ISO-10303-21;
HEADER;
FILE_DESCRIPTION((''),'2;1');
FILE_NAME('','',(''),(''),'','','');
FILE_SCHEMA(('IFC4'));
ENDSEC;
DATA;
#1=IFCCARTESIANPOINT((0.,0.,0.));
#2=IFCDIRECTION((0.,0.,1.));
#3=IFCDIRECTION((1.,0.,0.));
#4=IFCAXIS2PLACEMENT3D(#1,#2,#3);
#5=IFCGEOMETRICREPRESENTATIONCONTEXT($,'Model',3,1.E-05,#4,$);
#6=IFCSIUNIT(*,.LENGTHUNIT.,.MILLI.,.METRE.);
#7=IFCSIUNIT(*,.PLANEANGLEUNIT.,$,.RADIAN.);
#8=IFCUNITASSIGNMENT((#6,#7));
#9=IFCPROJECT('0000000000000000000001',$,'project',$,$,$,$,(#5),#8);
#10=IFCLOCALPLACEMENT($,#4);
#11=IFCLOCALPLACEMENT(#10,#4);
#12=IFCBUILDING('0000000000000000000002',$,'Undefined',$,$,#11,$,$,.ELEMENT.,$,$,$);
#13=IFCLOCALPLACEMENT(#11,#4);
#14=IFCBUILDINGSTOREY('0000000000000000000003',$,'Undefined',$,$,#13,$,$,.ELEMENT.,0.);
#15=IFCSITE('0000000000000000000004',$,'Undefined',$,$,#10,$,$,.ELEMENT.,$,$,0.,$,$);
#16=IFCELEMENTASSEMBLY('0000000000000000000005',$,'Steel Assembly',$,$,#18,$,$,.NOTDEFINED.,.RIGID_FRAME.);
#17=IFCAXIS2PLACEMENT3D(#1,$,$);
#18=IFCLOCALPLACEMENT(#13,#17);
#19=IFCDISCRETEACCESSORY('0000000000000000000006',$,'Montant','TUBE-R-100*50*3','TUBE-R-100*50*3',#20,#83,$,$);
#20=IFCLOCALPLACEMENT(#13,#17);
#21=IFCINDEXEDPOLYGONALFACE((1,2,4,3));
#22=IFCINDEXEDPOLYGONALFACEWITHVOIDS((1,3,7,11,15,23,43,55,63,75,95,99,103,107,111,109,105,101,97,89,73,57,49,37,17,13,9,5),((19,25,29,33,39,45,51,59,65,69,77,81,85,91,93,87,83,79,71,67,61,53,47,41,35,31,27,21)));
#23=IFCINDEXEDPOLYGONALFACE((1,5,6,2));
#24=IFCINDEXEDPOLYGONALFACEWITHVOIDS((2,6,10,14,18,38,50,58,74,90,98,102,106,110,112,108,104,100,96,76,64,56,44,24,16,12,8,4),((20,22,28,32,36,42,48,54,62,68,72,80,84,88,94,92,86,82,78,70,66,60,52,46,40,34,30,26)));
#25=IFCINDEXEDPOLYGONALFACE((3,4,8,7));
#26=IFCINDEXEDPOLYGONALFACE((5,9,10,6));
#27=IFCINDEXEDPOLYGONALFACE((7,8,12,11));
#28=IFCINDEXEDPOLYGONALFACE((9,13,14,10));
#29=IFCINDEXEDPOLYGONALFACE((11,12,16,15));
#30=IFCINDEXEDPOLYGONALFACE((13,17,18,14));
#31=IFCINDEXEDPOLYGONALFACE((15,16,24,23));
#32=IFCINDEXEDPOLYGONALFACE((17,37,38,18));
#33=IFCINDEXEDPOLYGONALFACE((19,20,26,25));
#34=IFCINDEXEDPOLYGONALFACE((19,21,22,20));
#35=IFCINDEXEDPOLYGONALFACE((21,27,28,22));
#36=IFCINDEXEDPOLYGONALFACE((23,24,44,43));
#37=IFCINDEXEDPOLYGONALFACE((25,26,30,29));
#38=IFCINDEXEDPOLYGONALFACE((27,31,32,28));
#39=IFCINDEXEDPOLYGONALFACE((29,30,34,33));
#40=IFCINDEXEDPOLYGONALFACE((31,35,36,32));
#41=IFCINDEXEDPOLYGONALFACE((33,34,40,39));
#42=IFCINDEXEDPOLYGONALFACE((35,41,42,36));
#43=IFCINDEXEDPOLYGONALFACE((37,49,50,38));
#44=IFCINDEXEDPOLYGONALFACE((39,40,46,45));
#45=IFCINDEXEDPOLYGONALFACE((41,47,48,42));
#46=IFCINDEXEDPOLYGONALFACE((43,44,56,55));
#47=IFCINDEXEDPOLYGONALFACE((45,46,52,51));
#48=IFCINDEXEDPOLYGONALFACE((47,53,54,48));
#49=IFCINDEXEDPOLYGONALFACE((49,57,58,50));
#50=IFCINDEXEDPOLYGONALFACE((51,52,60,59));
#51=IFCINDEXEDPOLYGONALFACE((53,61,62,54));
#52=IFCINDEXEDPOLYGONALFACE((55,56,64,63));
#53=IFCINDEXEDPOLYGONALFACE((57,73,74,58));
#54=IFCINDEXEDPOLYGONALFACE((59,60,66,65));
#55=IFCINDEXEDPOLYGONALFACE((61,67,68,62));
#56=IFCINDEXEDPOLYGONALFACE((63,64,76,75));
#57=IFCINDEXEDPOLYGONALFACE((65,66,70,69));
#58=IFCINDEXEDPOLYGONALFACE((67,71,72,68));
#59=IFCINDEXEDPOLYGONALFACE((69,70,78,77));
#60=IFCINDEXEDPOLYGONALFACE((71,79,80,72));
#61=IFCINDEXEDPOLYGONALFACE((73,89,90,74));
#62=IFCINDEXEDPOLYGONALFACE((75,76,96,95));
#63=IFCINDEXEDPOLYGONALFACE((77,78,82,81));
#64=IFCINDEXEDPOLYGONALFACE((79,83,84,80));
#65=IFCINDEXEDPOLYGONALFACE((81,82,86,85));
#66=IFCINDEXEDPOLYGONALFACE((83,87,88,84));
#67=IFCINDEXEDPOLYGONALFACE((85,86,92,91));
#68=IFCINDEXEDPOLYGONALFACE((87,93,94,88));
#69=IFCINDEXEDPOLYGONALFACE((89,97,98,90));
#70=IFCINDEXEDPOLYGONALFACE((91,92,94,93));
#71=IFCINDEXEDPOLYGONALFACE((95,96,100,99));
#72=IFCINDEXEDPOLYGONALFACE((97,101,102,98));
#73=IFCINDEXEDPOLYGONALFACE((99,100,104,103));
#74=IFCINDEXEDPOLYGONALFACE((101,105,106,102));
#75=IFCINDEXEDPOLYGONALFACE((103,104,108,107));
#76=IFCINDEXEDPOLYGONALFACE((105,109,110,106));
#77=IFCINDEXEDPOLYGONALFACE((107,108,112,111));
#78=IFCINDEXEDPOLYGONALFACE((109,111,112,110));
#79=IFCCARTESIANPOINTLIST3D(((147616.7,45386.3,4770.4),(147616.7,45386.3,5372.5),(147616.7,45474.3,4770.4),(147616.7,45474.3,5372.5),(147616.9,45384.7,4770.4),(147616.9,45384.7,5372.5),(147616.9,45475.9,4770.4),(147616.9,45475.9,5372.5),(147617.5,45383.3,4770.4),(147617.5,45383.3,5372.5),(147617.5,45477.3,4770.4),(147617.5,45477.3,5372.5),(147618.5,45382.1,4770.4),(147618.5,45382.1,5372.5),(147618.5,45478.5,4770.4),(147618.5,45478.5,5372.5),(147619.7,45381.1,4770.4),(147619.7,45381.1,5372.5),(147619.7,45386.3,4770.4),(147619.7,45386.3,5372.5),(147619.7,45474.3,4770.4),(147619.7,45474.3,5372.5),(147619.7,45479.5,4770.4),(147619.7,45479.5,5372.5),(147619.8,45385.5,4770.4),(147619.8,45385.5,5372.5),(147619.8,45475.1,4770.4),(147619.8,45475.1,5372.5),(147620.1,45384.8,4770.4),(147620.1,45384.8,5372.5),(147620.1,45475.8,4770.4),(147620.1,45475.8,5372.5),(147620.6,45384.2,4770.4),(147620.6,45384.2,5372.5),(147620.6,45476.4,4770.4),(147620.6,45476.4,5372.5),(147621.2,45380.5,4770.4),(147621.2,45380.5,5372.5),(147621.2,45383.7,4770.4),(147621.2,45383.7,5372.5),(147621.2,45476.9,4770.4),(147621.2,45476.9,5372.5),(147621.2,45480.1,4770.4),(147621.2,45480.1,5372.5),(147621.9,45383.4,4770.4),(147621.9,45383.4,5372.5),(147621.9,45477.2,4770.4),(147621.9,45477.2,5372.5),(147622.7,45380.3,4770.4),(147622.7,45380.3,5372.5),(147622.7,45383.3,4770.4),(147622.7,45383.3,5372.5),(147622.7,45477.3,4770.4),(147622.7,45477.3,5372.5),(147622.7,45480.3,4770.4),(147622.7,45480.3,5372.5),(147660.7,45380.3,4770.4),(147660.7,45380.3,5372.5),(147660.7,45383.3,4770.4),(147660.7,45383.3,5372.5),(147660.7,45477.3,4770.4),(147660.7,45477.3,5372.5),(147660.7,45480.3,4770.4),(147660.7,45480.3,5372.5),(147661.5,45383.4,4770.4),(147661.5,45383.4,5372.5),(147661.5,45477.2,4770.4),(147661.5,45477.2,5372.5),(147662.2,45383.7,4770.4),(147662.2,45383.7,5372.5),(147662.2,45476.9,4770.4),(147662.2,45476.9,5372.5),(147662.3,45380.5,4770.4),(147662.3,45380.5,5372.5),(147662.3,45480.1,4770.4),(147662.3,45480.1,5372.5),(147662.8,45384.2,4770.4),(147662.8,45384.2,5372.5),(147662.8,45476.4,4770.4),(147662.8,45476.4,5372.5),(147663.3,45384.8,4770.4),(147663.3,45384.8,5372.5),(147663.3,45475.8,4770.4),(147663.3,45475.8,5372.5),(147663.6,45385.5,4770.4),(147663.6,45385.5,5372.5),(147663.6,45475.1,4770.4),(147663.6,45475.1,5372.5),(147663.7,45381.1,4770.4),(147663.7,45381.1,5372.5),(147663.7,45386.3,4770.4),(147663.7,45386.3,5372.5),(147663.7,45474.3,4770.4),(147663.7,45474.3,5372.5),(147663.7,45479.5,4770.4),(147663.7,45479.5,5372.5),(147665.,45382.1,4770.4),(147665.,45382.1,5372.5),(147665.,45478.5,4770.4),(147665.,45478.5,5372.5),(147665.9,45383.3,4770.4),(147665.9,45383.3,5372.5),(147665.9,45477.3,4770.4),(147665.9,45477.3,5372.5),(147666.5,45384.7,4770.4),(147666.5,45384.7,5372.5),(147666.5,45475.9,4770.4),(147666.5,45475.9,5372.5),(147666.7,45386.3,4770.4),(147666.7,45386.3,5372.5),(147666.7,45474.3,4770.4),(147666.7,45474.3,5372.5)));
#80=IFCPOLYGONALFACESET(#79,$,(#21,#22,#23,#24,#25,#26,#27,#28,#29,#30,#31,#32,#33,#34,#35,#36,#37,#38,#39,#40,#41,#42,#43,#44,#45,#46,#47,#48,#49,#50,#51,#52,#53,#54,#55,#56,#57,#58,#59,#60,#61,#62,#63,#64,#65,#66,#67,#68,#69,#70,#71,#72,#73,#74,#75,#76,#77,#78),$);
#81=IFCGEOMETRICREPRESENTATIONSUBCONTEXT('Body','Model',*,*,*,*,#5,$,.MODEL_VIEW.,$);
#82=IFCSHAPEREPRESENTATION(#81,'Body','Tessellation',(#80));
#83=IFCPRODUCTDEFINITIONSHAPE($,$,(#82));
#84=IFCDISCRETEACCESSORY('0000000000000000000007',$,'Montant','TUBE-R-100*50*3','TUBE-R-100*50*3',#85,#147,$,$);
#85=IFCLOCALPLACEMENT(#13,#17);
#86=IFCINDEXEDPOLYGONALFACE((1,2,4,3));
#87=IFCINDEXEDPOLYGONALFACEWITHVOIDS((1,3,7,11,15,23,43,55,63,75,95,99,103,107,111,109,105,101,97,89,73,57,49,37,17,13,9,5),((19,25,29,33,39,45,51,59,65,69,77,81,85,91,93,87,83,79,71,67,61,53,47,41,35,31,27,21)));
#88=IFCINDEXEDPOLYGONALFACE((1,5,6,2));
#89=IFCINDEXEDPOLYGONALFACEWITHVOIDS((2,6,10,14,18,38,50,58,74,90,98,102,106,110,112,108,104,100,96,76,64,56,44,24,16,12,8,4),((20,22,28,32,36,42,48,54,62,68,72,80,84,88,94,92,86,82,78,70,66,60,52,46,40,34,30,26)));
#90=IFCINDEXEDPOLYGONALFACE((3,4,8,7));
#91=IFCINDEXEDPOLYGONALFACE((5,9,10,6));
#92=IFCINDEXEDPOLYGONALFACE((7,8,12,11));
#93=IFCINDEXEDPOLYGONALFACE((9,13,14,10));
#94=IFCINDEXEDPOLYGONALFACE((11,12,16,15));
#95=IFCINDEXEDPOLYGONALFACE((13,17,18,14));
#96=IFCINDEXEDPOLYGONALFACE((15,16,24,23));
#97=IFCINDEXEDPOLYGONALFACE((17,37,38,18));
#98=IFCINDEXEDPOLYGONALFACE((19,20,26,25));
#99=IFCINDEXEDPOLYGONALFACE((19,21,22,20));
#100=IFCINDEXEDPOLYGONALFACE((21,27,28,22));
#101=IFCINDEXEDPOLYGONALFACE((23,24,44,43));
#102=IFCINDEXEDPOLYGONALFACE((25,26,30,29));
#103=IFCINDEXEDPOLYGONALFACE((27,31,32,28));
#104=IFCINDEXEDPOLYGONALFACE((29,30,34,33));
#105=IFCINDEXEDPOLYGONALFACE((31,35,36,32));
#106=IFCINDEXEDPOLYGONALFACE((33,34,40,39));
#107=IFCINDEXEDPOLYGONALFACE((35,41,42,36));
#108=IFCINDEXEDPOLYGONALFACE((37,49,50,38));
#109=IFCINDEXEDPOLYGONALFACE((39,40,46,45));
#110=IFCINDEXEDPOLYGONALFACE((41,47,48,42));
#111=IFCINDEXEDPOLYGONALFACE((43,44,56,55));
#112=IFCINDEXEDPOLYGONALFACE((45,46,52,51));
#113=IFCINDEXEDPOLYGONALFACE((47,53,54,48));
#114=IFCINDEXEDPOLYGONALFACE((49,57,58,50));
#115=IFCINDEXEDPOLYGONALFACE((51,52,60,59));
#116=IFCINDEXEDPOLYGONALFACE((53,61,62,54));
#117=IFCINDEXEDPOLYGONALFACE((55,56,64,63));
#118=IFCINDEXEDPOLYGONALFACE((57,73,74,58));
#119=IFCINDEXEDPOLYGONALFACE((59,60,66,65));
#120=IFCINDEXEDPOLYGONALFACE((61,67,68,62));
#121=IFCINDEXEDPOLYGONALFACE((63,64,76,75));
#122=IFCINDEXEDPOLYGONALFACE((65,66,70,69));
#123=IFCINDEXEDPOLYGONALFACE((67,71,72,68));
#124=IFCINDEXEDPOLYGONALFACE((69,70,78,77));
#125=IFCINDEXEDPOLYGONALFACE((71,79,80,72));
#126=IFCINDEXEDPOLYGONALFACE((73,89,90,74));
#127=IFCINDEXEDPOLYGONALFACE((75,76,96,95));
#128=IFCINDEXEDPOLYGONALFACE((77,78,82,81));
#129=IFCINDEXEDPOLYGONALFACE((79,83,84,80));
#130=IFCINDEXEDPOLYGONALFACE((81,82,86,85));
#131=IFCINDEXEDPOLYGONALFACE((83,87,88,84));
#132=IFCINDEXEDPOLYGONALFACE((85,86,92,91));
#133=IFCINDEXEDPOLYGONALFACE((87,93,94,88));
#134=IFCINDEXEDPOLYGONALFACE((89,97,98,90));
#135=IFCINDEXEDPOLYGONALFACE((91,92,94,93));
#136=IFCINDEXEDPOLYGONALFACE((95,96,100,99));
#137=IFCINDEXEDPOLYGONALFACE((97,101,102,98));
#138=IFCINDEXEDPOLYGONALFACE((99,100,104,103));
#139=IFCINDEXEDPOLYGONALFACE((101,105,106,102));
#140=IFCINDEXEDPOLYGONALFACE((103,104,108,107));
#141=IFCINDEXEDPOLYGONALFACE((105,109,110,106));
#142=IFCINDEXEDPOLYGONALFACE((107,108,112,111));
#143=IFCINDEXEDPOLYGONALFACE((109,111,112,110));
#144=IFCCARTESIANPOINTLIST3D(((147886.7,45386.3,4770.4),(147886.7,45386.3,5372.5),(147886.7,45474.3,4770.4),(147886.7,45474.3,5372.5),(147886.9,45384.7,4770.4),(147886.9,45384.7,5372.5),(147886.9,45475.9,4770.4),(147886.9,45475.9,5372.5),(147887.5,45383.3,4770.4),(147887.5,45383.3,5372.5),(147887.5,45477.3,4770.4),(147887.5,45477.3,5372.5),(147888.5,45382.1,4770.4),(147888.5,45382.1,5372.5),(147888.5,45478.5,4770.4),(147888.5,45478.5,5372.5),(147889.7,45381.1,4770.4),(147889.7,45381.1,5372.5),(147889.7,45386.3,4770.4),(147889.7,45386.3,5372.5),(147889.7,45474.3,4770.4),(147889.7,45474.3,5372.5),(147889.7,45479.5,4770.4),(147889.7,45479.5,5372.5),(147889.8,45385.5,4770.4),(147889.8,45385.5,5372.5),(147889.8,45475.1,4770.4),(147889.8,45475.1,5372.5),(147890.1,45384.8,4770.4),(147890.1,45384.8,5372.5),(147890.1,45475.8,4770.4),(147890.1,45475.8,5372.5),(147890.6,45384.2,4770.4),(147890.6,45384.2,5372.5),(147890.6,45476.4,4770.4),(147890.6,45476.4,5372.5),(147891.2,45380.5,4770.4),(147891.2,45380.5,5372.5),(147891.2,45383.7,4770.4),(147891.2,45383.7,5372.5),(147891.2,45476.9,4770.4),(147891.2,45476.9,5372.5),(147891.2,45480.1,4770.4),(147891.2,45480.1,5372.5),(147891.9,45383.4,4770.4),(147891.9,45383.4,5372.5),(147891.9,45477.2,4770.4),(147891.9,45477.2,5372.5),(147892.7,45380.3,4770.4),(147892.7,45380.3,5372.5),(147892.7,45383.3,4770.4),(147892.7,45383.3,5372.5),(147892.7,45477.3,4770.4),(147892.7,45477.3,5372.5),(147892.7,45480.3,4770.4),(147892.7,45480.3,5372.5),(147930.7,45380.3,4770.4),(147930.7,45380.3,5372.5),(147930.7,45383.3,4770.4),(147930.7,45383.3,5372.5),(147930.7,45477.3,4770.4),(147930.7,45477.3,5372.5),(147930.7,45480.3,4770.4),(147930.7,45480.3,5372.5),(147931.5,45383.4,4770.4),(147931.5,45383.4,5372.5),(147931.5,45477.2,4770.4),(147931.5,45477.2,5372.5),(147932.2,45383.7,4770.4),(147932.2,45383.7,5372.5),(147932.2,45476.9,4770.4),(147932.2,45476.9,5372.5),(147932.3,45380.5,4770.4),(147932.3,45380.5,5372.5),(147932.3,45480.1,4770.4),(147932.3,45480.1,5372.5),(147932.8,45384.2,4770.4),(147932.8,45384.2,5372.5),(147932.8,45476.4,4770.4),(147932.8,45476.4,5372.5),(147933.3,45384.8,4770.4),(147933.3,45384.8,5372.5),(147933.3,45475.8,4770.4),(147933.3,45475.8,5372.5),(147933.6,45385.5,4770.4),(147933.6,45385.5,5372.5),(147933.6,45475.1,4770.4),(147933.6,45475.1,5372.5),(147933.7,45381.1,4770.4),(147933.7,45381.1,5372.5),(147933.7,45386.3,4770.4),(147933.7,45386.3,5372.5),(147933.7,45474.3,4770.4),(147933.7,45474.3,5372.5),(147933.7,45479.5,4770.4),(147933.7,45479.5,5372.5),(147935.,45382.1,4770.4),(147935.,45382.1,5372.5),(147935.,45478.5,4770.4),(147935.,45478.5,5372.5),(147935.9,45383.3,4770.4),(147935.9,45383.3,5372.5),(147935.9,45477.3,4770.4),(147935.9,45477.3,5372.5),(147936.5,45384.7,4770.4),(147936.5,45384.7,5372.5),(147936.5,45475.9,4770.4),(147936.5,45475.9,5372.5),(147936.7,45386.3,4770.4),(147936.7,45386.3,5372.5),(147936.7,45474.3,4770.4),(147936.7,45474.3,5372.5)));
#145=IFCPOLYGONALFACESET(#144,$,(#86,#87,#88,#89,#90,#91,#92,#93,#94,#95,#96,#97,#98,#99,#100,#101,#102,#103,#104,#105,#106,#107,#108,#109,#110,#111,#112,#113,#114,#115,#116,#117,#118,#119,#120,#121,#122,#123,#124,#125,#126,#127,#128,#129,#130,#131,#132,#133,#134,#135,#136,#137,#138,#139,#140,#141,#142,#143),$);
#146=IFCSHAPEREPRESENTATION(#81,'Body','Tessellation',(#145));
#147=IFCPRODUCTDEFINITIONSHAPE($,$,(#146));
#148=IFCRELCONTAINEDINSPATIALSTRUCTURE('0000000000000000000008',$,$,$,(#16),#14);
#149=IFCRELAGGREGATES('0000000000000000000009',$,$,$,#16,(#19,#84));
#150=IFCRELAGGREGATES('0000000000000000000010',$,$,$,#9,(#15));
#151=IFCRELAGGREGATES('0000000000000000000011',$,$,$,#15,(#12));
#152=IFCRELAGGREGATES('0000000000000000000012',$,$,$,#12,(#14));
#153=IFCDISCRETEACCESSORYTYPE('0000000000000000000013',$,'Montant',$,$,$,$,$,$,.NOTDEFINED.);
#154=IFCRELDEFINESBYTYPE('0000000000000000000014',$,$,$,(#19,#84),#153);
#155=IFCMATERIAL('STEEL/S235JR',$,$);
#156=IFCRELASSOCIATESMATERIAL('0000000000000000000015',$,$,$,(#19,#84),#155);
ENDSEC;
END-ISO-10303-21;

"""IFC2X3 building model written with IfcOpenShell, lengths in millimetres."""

from ifc_helpers import new_model, si_unit, frame, origin_with_axes, origin_2d_with_axis, place, context, subcontext, project, spatial, hollow_rectangle, extrude, material, type_object, element, aggregate, save


model = new_model("IFC2X3")

# Units and contexts
model_context = context("Model", 3, precision=1e-05, world=origin_with_axes())
body_context = subcontext(model_context, "Body", "Model", "MODEL_VIEW")
ifc_project = project(units=[si_unit("LENGTHUNIT", "METRE", prefix="MILLI"), si_unit("PLANEANGLEUNIT", "RADIAN")], contexts=[model_context])

# Site, building, storey
site_placement = place(None, origin_with_axes())
site = spatial("IfcSite", under=ifc_project, at=site_placement, Name="Undefined", CompositionType="ELEMENT", RefElevation=0.0)
building_placement = place(site_placement, origin_with_axes())
building = spatial("IfcBuilding", under=site, at=building_placement, Name="Undefined", CompositionType="ELEMENT")
storey_placement = place(building_placement, origin_with_axes())
storey = spatial("IfcBuildingStorey", under=building, at=storey_placement, Name="Undefined", CompositionType="ELEMENT", Elevation=0.0)

# Element assembly
ifc_material_1 = material(Name="STEEL/S235JR")
assembly_1_placement = place(storey_placement, origin_with_axes())
assembly_1 = element("IfcElementAssembly", 1, at=assembly_1_placement, inside=storey, Name="Steel Assembly", AssemblyPlace="NOTDEFINED", PredefinedType="RIGID_FRAME")

# Discrete accessories
discrete_accessory_type_1 = type_object("IfcDiscreteAccessoryType", Name="Montant")
discrete_accessory_1_placement = place(assembly_1_placement, frame((147641.7, 45430.3, 4770.4), z_axis=(0.0, 0.0, 1.0), x_axis=(1.0, 0.0, 0.0)))
discrete_accessory_1 = element("IfcDiscreteAccessory", 2, at=discrete_accessory_1_placement, type_object=discrete_accessory_type_1, material=ifc_material_1, Name="Montant", Description="TUBE-R-100*50*3", ObjectType="TUBE-R-100*50*3", context=body_context, shape_type="SweptSolid", body=[
    extrude(hollow_rectangle(XDim=50.0, YDim=100.0, WallThickness=3.0, InnerFilletRadius=3.0, OuterFilletRadius=6.0, at=origin_2d_with_axis()), frame((0.0, 0.0, 602.1), z_axis=(0.0, 0.0, -1.0), x_axis=(1.0, 0.0, 0.0)), (0.0, 0.0, 1.0), 602.1),
])
discrete_accessory_2_placement = place(assembly_1_placement, frame((147911.7, 45430.3, 4770.4), z_axis=(0.0, 0.0, 1.0), x_axis=(1.0, 0.0, 0.0)))
discrete_accessory_2 = element("IfcDiscreteAccessory", 3, at=discrete_accessory_2_placement, type_object=discrete_accessory_type_1, material=ifc_material_1, Name="Montant", Description="TUBE-R-100*50*3", ObjectType="TUBE-R-100*50*3", context=body_context, shape_type="SweptSolid", body=[
    extrude(hollow_rectangle(XDim=50.0, YDim=100.0, WallThickness=3.0, InnerFilletRadius=3.0, OuterFilletRadius=6.0, at=origin_2d_with_axis()), frame((0.0, 0.0, 602.1), z_axis=(0.0, 0.0, -1.0), x_axis=(1.0, 0.0, 0.0)), (0.0, 0.0, 1.0), 602.1),
])
aggregate(assembly_1, [discrete_accessory_1, discrete_accessory_2])

save(model, "model.ifc")
